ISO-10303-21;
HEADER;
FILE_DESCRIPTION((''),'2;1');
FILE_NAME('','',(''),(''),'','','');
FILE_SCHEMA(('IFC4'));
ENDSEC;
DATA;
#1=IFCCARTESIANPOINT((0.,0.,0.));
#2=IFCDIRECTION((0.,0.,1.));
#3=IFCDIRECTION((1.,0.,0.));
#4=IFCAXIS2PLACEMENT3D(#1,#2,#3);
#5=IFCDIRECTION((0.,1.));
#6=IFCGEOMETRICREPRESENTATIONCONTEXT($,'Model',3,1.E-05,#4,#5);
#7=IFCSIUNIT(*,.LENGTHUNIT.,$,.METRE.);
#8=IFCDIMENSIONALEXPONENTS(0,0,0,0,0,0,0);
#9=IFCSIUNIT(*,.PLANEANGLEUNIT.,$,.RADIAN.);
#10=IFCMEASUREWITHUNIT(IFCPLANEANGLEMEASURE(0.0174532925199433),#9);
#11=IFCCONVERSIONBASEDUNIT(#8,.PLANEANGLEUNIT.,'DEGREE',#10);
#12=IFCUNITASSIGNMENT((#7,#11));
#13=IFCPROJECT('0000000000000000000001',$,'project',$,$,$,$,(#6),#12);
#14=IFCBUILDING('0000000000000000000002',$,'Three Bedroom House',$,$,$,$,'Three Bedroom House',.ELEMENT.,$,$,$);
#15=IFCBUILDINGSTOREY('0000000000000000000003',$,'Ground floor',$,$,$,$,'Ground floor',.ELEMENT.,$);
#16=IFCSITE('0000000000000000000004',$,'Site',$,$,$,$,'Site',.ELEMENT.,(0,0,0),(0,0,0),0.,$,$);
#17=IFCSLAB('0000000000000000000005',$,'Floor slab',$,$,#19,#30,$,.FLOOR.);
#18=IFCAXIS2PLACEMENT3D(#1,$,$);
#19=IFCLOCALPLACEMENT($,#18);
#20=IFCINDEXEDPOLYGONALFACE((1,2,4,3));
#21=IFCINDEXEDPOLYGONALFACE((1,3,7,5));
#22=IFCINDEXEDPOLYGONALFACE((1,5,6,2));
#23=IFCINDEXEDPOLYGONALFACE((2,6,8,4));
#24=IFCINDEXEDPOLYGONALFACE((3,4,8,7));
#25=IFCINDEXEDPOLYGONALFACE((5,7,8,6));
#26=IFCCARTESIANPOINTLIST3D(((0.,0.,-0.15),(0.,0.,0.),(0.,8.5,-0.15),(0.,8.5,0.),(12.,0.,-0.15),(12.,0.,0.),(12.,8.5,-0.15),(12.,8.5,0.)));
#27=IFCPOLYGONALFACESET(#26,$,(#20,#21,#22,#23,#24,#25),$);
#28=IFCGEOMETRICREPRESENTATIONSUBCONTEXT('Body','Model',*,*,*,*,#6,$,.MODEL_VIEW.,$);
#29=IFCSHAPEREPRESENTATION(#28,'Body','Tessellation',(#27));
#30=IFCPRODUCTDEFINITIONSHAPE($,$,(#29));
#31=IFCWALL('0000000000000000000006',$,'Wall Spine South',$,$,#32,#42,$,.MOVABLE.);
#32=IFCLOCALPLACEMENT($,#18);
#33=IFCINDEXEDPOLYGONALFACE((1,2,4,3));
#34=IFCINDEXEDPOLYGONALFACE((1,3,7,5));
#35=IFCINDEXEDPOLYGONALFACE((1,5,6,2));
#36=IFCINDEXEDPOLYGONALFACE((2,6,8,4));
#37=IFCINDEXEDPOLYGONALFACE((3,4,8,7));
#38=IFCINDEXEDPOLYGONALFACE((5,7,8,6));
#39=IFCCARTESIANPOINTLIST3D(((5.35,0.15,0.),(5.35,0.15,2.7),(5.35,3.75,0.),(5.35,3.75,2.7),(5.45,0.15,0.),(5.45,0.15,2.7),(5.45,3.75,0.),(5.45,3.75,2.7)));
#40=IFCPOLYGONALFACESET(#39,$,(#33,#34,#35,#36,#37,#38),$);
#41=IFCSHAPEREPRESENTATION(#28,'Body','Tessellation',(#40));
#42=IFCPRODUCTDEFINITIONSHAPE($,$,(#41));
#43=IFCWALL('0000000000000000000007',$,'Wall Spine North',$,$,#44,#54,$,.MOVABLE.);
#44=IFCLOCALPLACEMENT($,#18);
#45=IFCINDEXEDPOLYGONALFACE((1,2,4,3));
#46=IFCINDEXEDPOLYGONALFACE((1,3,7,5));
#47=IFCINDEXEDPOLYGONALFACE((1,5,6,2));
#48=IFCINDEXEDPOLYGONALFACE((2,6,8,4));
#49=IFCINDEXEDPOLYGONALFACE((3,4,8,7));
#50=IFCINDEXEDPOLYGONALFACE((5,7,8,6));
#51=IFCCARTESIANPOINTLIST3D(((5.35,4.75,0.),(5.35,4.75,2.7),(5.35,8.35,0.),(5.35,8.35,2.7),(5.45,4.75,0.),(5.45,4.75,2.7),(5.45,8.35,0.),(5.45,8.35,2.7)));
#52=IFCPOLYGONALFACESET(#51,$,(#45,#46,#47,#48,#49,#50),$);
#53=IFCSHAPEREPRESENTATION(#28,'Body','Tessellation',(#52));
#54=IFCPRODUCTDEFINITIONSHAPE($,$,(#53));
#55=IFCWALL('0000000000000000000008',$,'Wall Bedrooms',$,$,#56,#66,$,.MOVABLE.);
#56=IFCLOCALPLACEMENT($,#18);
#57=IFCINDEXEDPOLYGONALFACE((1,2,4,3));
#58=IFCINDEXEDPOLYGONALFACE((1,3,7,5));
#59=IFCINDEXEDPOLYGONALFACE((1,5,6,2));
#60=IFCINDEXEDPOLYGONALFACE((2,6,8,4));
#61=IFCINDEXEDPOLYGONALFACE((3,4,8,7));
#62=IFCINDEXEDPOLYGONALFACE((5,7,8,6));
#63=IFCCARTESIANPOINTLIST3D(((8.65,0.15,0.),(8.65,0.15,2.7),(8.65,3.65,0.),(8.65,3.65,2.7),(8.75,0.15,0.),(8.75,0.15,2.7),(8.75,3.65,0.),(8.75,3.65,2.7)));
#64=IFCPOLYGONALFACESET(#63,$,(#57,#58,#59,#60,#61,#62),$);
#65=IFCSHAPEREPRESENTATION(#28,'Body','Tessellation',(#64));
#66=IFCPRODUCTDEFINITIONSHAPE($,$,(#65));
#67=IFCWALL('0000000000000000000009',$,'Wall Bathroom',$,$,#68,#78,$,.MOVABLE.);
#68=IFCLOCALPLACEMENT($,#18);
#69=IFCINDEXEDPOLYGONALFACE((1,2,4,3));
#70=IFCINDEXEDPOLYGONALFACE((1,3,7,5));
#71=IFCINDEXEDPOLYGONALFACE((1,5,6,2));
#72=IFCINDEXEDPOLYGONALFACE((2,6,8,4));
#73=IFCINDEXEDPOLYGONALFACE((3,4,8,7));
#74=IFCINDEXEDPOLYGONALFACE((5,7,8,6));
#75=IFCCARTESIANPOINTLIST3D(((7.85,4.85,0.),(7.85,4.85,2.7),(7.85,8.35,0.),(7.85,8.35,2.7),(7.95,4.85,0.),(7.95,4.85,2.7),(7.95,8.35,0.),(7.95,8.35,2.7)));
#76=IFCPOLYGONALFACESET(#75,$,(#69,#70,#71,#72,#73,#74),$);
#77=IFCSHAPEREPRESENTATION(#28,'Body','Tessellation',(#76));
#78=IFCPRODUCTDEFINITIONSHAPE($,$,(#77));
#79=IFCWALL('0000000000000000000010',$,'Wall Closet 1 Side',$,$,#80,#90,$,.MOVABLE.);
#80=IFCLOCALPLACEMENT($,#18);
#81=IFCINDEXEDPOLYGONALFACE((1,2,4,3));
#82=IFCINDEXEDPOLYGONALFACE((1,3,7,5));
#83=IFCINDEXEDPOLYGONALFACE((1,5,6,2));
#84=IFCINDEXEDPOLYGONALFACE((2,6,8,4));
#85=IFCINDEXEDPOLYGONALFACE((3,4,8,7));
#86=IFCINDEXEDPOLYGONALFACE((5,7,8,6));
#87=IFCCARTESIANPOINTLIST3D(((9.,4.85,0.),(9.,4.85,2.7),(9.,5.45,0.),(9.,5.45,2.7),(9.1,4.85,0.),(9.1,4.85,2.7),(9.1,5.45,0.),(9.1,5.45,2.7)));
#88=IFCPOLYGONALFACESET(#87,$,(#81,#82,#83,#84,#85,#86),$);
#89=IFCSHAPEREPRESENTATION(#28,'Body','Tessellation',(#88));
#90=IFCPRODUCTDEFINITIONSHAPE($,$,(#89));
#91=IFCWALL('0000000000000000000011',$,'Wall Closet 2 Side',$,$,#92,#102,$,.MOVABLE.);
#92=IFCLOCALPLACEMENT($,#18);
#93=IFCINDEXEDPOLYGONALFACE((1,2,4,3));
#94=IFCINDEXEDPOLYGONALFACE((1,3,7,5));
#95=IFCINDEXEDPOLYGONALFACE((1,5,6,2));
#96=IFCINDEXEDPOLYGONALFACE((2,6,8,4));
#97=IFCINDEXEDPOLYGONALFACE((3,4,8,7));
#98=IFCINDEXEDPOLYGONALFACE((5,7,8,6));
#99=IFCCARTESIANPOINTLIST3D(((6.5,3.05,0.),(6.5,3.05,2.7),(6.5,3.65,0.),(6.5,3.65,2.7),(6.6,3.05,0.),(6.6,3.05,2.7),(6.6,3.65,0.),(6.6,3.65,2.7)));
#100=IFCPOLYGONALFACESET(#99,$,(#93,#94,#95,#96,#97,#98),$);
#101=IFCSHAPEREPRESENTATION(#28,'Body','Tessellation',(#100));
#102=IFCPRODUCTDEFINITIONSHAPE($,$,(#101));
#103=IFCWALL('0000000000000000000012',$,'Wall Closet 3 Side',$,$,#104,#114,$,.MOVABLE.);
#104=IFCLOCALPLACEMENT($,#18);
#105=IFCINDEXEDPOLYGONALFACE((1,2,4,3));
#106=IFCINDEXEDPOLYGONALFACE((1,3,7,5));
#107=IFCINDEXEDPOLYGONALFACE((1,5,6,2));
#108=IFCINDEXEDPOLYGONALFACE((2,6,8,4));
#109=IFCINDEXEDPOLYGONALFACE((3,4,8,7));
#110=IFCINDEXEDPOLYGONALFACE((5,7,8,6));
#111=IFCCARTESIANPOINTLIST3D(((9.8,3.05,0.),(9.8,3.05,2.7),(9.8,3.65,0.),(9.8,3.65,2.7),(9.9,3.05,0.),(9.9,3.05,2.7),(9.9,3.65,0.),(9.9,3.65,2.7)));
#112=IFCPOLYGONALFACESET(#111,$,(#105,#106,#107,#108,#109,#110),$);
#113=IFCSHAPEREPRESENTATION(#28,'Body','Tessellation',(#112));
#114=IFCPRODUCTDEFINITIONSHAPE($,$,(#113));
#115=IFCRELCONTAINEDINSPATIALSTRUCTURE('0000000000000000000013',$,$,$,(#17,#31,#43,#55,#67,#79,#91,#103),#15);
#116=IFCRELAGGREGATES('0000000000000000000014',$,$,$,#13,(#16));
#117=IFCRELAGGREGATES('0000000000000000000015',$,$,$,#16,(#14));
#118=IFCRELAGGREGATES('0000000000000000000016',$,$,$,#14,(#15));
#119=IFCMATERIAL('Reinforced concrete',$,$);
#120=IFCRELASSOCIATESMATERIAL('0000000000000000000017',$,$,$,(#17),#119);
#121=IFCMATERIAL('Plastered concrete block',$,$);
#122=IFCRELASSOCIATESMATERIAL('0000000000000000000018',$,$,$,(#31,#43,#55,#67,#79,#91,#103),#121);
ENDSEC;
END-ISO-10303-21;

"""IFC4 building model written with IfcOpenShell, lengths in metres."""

from ifc_helpers import new_model, entity, si_unit, converted_unit, direction, frame, frame_2d, origin_with_axes, origin_2d_with_axis, place, context, subcontext, project, spatial, rectangle, extrude, material, element, save


model = new_model("IFC4")

# Units and contexts
model_context = context("Model", 3, precision=1e-05, world=origin_with_axes(), true_north=direction((0.0, 1.0)))
body_context = subcontext(model_context, "Body", "Model", "MODEL_VIEW")
ifc_project = project(units=[si_unit("LENGTHUNIT", "METRE"), converted_unit("PLANEANGLEUNIT", "DEGREE", entity("IfcPlaneAngleMeasure", 0.0174532925199433), si_unit("PLANEANGLEUNIT", "RADIAN"), dimensions=[0, 0, 0, 0, 0, 0, 0])], contexts=[model_context])

# Site, building, storey
site = spatial("IfcSite", under=ifc_project, Name="Site", LongName="Site", CompositionType="ELEMENT", RefLatitude=(0, 0, 0), RefLongitude=(0, 0, 0), RefElevation=0.0)
building = spatial("IfcBuilding", under=site, Name="Three Bedroom House", LongName="Three Bedroom House", CompositionType="ELEMENT")
storey = spatial("IfcBuildingStorey", under=building, Name="Ground floor", LongName="Ground floor", CompositionType="ELEMENT")

# Slab
ifc_material_1 = material(Name="Reinforced concrete")
placement = place(None, origin_with_axes())
element("IfcSlab", 1, at=placement, inside=storey, material=ifc_material_1, Name="Floor slab", PredefinedType="FLOOR", context=body_context, shape_type="SweptSolid", body=[
    extrude(rectangle(XDim=12.0, YDim=8.5, at=origin_2d_with_axis()), frame((6.0, 4.25, -0.15), z_axis=(0.0, 0.0, 1.0), x_axis=(1.0, 0.0, 0.0)), (0.0, 0.0, 1.0), 0.15),
])

# Walls
ifc_material_2 = material(Name="Plastered concrete block")
element("IfcWall", 2, at=placement, inside=storey, material=ifc_material_2, Name="Wall Spine South", PredefinedType="MOVABLE", context=body_context, shape_type="SweptSolid", body=[
    extrude(rectangle(XDim=3.6, YDim=0.1, at=frame_2d((0.0, 0.0), x_axis=(0.0, 1.0))), frame((5.4, 1.95, 0.0), z_axis=(0.0, 0.0, 1.0), x_axis=(1.0, 0.0, 0.0)), (0.0, 0.0, 1.0), 2.7),
])
element("IfcWall", 3, at=placement, inside=storey, material=ifc_material_2, Name="Wall Spine North", PredefinedType="MOVABLE", context=body_context, shape_type="SweptSolid", body=[
    extrude(rectangle(XDim=3.6, YDim=0.1, at=frame_2d((0.0, 0.0), x_axis=(0.0, 1.0))), frame((5.4, 6.55, 0.0), z_axis=(0.0, 0.0, 1.0), x_axis=(1.0, 0.0, 0.0)), (0.0, 0.0, 1.0), 2.7),
])
element("IfcWall", 4, at=placement, inside=storey, material=ifc_material_2, Name="Wall Bedrooms", PredefinedType="MOVABLE", context=body_context, shape_type="SweptSolid", body=[
    extrude(rectangle(XDim=3.5, YDim=0.1, at=frame_2d((0.0, 0.0), x_axis=(0.0, 1.0))), frame((8.7, 1.9, 0.0), z_axis=(0.0, 0.0, 1.0), x_axis=(1.0, 0.0, 0.0)), (0.0, 0.0, 1.0), 2.7),
])
element("IfcWall", 5, at=placement, inside=storey, material=ifc_material_2, Name="Wall Bathroom", PredefinedType="MOVABLE", context=body_context, shape_type="SweptSolid", body=[
    extrude(rectangle(XDim=3.5, YDim=0.1, at=frame_2d((0.0, 0.0), x_axis=(0.0, 1.0))), frame((7.9, 6.6, 0.0), z_axis=(0.0, 0.0, 1.0), x_axis=(1.0, 0.0, 0.0)), (0.0, 0.0, 1.0), 2.7),
])
element("IfcWall", 6, at=placement, inside=storey, material=ifc_material_2, Name="Wall Closet 1 Side", PredefinedType="MOVABLE", context=body_context, shape_type="SweptSolid", body=[
    extrude(rectangle(XDim=0.6, YDim=0.1, at=frame_2d((0.0, 0.0), x_axis=(0.0, 1.0))), frame((9.05, 5.15, 0.0), z_axis=(0.0, 0.0, 1.0), x_axis=(1.0, 0.0, 0.0)), (0.0, 0.0, 1.0), 2.7),
])
element("IfcWall", 7, at=placement, inside=storey, material=ifc_material_2, Name="Wall Closet 2 Side", PredefinedType="MOVABLE", context=body_context, shape_type="SweptSolid", body=[
    extrude(rectangle(XDim=0.6, YDim=0.1, at=frame_2d((0.0, 0.0), x_axis=(0.0, 1.0))), frame((6.55, 3.35, 0.0), z_axis=(0.0, 0.0, 1.0), x_axis=(1.0, 0.0, 0.0)), (0.0, 0.0, 1.0), 2.7),
])
element("IfcWall", 8, at=placement, inside=storey, material=ifc_material_2, Name="Wall Closet 3 Side", PredefinedType="MOVABLE", context=body_context, shape_type="SweptSolid", body=[
    extrude(rectangle(XDim=0.6, YDim=0.1, at=frame_2d((0.0, 0.0), x_axis=(0.0, 1.0))), frame((9.85, 3.35, 0.0), z_axis=(0.0, 0.0, 1.0), x_axis=(1.0, 0.0, 0.0)), (0.0, 0.0, 1.0), 2.7),
])

save(model, "model.ifc")
